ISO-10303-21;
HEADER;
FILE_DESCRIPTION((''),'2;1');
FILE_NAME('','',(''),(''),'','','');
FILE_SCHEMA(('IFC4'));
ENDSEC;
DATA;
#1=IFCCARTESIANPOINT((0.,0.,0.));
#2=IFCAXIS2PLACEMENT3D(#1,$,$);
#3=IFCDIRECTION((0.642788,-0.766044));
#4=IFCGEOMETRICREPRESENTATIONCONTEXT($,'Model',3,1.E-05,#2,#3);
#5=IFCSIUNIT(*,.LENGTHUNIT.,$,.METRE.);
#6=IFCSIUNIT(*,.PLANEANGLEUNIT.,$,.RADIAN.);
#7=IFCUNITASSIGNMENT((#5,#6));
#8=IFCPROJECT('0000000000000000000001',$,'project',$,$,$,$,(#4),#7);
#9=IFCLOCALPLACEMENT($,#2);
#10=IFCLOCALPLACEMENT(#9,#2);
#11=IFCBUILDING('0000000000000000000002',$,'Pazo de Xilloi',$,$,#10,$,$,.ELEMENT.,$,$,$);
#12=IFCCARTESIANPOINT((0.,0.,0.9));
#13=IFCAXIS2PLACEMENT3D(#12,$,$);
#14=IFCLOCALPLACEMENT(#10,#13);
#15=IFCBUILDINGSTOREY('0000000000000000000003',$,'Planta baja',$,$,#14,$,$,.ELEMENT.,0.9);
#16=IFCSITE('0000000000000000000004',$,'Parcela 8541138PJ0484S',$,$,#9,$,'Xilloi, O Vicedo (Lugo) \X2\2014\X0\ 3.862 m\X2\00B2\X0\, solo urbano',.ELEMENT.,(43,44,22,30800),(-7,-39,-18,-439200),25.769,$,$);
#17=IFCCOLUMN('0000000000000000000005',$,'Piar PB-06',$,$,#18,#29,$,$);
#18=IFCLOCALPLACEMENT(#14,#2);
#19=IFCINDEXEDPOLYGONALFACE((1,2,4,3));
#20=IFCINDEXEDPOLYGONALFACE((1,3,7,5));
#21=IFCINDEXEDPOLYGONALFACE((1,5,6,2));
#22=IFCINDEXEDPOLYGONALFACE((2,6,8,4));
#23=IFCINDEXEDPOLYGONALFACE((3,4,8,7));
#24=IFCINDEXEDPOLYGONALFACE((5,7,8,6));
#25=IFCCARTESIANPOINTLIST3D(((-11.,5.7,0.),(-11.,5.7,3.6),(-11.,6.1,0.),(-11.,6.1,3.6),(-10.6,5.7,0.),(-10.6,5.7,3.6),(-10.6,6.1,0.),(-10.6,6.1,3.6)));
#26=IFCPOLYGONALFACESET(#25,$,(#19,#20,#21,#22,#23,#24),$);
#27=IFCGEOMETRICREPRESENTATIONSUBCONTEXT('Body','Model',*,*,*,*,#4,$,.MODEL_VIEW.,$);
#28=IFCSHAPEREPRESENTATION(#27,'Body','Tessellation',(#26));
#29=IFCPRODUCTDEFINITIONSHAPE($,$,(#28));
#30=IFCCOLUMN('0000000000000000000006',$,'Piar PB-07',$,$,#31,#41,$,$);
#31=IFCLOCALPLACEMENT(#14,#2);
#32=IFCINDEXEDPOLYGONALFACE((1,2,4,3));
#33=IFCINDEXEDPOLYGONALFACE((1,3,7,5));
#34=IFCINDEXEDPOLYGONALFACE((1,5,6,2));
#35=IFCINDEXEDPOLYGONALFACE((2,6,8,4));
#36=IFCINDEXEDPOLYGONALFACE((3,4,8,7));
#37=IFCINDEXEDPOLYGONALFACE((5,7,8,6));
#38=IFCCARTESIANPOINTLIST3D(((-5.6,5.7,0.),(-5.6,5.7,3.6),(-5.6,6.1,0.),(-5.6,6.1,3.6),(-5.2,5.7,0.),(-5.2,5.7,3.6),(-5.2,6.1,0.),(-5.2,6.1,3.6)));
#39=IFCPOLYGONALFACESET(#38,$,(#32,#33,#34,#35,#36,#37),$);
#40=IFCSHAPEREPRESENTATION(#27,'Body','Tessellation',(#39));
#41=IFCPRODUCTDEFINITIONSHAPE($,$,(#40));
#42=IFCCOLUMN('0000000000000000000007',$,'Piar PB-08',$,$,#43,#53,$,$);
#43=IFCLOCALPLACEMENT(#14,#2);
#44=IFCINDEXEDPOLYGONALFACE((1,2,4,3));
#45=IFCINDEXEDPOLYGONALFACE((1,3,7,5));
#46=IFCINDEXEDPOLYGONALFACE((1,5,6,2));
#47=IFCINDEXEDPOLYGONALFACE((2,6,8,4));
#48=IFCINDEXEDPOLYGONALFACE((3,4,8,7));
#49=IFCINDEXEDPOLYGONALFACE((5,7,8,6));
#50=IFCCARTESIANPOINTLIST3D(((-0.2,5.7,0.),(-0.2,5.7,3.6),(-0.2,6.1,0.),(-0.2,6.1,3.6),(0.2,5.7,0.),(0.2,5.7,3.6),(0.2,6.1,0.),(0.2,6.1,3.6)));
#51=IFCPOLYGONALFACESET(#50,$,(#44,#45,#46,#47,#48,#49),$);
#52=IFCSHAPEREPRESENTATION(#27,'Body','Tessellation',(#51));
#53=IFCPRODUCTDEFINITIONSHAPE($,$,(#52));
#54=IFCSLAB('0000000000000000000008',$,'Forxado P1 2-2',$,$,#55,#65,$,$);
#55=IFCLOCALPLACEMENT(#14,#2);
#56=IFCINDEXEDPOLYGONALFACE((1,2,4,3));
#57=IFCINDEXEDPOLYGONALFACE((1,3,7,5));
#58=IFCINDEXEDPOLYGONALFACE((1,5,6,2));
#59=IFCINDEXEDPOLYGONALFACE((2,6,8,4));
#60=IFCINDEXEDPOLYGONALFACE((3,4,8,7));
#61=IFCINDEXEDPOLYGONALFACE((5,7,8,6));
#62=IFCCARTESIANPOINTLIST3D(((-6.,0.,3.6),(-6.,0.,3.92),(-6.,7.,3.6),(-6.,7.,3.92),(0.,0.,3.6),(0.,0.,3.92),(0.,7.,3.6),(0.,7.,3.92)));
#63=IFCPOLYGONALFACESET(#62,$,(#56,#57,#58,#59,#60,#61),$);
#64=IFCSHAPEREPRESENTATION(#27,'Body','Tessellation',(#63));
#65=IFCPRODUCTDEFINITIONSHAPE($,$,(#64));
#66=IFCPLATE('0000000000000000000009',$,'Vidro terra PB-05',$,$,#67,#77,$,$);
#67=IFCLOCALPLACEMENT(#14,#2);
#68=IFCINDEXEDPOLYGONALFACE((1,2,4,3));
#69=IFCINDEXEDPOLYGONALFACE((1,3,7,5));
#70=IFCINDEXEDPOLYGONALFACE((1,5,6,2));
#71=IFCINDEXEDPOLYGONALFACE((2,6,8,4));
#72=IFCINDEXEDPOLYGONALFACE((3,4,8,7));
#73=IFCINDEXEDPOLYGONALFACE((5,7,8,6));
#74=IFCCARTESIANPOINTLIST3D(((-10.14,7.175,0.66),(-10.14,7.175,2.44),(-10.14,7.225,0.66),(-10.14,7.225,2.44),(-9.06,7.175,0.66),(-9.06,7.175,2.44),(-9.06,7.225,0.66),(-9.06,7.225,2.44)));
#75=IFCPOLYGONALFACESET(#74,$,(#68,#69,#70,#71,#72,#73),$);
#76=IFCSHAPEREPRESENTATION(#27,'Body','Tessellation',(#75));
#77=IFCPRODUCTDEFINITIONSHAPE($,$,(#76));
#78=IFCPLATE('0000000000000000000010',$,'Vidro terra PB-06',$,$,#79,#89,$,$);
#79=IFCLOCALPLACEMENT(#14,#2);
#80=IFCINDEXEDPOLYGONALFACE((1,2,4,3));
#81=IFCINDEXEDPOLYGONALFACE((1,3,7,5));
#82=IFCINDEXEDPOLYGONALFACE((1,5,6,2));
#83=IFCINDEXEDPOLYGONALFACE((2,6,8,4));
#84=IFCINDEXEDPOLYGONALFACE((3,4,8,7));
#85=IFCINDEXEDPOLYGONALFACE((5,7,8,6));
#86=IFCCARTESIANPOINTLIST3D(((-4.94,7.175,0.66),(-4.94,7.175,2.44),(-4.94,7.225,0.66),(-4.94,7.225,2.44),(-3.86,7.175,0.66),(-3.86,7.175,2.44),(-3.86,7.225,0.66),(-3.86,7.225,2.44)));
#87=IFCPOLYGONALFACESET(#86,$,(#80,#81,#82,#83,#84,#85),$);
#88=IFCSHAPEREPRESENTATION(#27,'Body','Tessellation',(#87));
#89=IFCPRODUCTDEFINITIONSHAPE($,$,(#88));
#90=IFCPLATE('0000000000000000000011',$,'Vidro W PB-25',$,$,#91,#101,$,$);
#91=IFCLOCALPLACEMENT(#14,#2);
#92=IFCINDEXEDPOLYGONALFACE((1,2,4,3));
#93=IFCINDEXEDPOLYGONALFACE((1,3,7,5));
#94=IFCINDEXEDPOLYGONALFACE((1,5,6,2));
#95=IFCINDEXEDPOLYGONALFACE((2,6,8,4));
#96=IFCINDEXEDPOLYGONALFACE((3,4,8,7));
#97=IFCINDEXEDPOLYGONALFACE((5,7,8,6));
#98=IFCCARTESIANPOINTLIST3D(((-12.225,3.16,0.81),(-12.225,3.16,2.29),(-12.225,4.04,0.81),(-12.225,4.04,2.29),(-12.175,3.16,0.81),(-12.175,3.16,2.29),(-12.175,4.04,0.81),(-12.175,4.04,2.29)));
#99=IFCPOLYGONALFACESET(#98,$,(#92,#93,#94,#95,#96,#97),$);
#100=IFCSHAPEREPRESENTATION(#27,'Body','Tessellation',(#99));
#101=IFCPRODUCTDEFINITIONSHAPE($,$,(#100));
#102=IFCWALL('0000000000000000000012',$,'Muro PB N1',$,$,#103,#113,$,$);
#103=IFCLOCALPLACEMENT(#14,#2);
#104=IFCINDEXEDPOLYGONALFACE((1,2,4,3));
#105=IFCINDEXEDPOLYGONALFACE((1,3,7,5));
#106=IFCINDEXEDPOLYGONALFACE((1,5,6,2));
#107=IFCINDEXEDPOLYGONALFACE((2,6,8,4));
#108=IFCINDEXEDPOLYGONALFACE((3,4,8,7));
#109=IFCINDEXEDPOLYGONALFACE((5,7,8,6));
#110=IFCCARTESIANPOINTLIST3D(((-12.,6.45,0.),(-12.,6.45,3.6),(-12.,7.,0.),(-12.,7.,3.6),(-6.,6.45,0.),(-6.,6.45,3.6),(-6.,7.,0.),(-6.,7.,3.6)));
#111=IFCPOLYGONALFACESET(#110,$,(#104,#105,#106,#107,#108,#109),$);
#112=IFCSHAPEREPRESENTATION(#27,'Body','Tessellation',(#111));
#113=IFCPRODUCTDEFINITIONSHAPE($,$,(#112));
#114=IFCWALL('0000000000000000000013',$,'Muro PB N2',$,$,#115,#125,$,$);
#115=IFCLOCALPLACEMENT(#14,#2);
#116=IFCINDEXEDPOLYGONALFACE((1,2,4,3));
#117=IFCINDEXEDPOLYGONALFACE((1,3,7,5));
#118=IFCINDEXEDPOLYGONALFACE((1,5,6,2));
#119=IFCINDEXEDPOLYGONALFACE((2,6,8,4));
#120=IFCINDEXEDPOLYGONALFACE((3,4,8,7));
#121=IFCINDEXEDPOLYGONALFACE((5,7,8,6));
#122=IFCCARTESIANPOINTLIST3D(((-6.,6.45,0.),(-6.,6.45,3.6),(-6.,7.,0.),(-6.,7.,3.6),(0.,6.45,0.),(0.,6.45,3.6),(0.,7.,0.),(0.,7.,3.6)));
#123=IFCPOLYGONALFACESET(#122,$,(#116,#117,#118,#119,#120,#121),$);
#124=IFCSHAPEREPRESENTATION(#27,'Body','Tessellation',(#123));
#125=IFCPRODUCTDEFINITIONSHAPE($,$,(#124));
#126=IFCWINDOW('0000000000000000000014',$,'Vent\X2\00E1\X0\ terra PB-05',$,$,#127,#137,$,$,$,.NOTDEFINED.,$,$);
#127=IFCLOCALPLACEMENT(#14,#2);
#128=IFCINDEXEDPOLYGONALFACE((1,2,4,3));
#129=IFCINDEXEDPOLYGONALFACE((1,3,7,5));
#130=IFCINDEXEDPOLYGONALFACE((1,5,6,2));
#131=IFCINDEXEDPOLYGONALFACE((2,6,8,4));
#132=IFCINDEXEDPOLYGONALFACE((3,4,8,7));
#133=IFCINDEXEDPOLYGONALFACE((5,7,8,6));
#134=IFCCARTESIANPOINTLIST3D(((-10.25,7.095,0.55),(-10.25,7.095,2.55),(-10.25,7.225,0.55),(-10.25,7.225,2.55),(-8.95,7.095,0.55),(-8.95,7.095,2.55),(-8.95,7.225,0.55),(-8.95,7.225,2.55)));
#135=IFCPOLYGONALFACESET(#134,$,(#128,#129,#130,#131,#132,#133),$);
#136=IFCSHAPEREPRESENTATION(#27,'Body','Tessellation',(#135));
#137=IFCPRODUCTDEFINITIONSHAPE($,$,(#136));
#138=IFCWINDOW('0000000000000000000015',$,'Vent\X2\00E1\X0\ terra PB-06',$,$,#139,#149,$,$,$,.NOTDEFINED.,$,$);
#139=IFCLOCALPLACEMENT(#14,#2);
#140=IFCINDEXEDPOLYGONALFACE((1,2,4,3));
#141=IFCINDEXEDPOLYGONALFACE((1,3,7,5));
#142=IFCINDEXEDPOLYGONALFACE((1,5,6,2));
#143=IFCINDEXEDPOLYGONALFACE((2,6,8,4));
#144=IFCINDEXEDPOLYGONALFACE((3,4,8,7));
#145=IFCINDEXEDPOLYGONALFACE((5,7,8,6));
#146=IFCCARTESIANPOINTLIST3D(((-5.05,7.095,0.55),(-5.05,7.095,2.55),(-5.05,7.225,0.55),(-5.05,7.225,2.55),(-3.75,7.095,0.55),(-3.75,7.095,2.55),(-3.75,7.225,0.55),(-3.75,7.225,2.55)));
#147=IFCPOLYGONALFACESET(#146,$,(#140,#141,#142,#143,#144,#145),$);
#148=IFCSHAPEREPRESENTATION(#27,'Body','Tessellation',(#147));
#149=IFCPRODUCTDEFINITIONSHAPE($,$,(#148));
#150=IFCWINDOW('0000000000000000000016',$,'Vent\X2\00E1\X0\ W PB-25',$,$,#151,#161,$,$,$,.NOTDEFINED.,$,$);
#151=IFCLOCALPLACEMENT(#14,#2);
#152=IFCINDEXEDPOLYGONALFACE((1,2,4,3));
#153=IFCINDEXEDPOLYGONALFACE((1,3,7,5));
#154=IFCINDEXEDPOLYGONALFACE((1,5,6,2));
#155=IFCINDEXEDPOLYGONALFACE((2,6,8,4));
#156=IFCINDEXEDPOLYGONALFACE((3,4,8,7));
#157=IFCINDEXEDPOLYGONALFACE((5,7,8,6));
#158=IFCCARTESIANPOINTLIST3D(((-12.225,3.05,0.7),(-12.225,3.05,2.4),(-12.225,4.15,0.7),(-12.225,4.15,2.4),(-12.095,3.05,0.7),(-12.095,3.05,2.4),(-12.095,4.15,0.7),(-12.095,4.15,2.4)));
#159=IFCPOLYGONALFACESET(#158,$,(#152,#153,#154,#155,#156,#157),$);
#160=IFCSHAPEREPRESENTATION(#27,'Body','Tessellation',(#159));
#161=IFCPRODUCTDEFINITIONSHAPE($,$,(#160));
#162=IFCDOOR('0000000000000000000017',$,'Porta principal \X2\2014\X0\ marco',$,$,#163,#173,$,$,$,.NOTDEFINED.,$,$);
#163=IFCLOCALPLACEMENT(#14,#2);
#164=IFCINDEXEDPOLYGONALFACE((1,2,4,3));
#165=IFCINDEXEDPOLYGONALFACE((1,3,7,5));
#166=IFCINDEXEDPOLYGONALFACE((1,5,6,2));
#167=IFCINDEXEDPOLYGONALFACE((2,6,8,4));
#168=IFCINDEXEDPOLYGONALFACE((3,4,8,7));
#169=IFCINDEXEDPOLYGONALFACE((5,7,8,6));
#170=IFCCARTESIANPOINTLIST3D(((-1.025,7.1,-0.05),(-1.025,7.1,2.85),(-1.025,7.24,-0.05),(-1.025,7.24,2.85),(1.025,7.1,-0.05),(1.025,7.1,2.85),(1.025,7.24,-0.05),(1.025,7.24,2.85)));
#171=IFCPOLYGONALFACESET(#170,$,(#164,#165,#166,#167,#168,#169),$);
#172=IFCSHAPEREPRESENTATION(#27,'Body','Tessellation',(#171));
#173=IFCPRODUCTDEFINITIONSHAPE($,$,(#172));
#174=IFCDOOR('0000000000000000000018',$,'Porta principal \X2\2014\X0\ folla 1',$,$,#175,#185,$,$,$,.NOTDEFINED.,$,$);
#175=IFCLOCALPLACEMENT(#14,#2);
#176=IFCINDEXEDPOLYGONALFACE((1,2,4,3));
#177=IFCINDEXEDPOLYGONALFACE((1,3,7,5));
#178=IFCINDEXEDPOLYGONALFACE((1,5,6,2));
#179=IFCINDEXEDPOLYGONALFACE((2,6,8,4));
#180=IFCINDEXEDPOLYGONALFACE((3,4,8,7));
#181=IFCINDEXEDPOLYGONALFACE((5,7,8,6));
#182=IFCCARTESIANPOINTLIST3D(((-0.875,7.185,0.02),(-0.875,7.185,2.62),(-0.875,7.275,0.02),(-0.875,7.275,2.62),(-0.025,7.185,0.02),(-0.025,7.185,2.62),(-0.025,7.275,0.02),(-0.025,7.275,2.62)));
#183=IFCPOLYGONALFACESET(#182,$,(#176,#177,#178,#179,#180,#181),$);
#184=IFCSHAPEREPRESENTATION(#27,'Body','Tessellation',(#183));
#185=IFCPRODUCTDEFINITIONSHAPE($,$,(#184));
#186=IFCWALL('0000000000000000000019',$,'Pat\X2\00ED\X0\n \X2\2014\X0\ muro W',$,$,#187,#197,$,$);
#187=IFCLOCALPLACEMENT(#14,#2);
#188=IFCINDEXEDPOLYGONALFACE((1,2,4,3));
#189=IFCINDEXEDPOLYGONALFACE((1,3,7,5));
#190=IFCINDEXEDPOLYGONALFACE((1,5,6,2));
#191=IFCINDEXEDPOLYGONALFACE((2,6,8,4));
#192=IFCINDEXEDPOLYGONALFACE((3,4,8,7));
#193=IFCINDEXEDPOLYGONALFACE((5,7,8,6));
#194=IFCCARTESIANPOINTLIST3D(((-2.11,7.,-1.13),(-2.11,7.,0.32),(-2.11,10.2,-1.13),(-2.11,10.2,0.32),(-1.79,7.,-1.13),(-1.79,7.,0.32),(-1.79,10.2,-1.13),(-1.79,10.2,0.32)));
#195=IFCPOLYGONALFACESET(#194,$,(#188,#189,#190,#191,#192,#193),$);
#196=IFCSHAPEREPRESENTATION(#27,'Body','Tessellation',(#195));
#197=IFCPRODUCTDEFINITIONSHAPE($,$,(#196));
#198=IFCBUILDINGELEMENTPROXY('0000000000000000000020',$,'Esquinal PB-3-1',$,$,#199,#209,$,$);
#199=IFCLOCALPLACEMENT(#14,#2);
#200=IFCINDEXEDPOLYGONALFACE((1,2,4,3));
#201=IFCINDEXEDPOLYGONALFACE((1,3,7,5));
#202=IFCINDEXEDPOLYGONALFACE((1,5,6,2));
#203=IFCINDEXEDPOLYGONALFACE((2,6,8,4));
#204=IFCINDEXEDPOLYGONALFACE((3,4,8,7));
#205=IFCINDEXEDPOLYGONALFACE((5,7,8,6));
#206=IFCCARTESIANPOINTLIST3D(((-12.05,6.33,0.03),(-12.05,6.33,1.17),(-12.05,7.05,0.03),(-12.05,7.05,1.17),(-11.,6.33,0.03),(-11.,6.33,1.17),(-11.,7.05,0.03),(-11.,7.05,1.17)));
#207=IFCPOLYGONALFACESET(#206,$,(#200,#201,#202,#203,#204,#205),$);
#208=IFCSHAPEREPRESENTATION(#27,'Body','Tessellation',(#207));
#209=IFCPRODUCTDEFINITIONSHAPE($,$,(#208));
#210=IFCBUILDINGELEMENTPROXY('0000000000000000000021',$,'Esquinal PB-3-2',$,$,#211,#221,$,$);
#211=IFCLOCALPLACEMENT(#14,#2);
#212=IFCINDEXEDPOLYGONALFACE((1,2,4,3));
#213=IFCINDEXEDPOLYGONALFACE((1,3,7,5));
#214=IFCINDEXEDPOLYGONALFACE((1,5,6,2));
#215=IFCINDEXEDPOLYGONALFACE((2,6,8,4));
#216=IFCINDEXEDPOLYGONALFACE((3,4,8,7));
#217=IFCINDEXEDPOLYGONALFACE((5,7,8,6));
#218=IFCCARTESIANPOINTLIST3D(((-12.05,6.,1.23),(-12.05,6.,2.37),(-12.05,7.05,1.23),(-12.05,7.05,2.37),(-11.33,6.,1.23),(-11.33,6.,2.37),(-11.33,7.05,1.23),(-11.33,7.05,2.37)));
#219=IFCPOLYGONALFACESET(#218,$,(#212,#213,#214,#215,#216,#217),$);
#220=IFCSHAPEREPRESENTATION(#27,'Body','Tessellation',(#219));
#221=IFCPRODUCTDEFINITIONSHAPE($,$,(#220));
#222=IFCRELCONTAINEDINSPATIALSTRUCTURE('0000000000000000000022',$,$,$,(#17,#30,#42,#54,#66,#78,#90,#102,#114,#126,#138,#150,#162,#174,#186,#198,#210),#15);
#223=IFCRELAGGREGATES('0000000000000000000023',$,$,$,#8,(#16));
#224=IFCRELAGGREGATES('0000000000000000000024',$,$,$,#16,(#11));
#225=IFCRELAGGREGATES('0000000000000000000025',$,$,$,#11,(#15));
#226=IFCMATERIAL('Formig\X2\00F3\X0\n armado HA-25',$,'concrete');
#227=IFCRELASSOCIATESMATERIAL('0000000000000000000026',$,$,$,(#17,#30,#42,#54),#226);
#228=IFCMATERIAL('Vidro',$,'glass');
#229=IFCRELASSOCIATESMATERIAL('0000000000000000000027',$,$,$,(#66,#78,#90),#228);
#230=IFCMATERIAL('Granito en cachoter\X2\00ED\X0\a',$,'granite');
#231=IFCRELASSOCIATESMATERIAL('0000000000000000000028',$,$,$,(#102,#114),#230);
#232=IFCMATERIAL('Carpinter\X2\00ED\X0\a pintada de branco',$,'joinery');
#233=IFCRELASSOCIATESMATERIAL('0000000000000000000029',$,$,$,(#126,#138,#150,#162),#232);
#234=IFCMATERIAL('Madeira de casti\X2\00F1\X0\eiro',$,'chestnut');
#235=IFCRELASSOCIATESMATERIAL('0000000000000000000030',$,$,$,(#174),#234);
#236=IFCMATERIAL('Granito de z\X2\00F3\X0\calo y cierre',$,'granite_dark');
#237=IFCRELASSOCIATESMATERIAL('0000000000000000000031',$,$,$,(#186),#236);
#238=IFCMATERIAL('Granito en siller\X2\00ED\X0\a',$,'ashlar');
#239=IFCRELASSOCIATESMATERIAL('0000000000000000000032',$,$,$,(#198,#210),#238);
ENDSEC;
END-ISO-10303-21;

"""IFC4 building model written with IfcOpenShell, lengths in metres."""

from ifc_helpers import new_model, si_unit, direction, frame, origin, origin_2d, place, context, subcontext, project, spatial, rectangle, extrude, material, element, save


model = new_model("IFC4")

# Units and contexts
model_context = context("Model", 3, precision=1e-05, world=origin(), true_north=direction((0.642788, -0.766044)))
body_context = subcontext(model_context, "Body", "Model", "MODEL_VIEW")
ifc_project = project(units=[si_unit("LENGTHUNIT", "METRE"), si_unit("PLANEANGLEUNIT", "RADIAN")], contexts=[model_context])

# Site, building, storey
site_placement = place(None, origin())
site = spatial("IfcSite", under=ifc_project, at=site_placement, Name="Parcela 8541138PJ0484S", LongName="Xilloi, O Vicedo (Lugo) — 3.862 m², solo urbano", CompositionType="ELEMENT", RefLatitude=(43, 44, 22, 30800), RefLongitude=(-7, -39, -18, -439200), RefElevation=25.769)
building_placement = place(site_placement, origin())
building = spatial("IfcBuilding", under=site, at=building_placement, Name="Pazo de Xilloi", CompositionType="ELEMENT")
storey_placement = place(building_placement, frame((0.0, 0.0, 0.9)))
storey = spatial("IfcBuildingStorey", under=building, at=storey_placement, Name="Planta baja", CompositionType="ELEMENT", Elevation=0.9)

# Columns
ifc_material_1 = material(Name="Formigón armado HA-25", Category="concrete")
for number, where, name in (
    (1, (-10.8, 5.9, 1.8), "Piar PB-06"),
    (2, (-5.4, 5.9, 1.8), "Piar PB-07"),
    (3, (0.0, 5.9, 1.8), "Piar PB-08"),
):
    element("IfcColumn", number, at=place(storey_placement, frame(where)), inside=storey, material=ifc_material_1, Name=name, context=body_context, shape_type="SweptSolid", body=[
        extrude(rectangle(XDim=0.4, YDim=0.4, at=origin_2d()), frame((0.0, 0.0, -1.8)), (0.0, 0.0, 1.0), 3.6),
    ])

# Slab
slab_placement = place(storey_placement, frame((-3.0, 3.5, 3.76)))
element("IfcSlab", 4, at=slab_placement, inside=storey, material=ifc_material_1, Name="Forxado P1 2-2", context=body_context, shape_type="SweptSolid", body=[
    extrude(rectangle(XDim=6.0, YDim=7.0, at=origin_2d()), frame((0.0, 0.0, -0.16)), (0.0, 0.0, 1.0), 0.32),
])

# Plates
ifc_material_2 = material(Name="Vidro", Category="glass")
for number, where, name in (
    (5, (-9.6, 7.2, 1.55), "Vidro terra PB-05"),
    (6, (-4.4, 7.2, 1.55), "Vidro terra PB-06"),
):
    element("IfcPlate", number, at=place(storey_placement, frame(where)), inside=storey, material=ifc_material_2, Name=name, context=body_context, shape_type="SweptSolid", body=[
        extrude(rectangle(XDim=1.08, YDim=0.05, at=origin_2d()), frame((0.0, 0.0, -0.89)), (0.0, 0.0, 1.0), 1.78),
    ])
plate_placement = place(storey_placement, frame((-12.2, 3.6, 1.55)))
element("IfcPlate", 7, at=plate_placement, inside=storey, material=ifc_material_2, Name="Vidro W PB-25", context=body_context, shape_type="SweptSolid", body=[
    extrude(rectangle(XDim=0.05, YDim=0.88, at=origin_2d()), frame((0.0, 0.0, -0.74)), (0.0, 0.0, 1.0), 1.48),
])

# Walls
ifc_material_3 = material(Name="Granito en cachotería", Category="granite")
for number, where, name in (
    (8, (-9.0, 6.725, 1.8), "Muro PB N1"),
    (9, (-3.0, 6.725, 1.8), "Muro PB N2"),
):
    element("IfcWall", number, at=place(storey_placement, frame(where)), inside=storey, material=ifc_material_3, Name=name, context=body_context, shape_type="SweptSolid", body=[
        extrude(rectangle(XDim=6.0, YDim=0.55, at=origin_2d()), frame((0.0, 0.0, -1.8)), (0.0, 0.0, 1.0), 3.6),
    ])

# Windows
ifc_material_4 = material(Name="Carpintería pintada de branco", Category="joinery")
for number, where, name in (
    (10, (-9.6, 7.16, 1.55), "Ventá terra PB-05"),
    (11, (-4.4, 7.16, 1.55), "Ventá terra PB-06"),
):
    element("IfcWindow", number, at=place(storey_placement, frame(where)), inside=storey, material=ifc_material_4, Name=name, PredefinedType="NOTDEFINED", context=body_context, shape_type="SweptSolid", body=[
        extrude(rectangle(XDim=1.3, YDim=0.13, at=origin_2d()), frame((0.0, 0.0, -1.0)), (0.0, 0.0, 1.0), 2.0),
    ])
window_placement = place(storey_placement, frame((-12.16, 3.6, 1.55)))
element("IfcWindow", 12, at=window_placement, inside=storey, material=ifc_material_4, Name="Ventá W PB-25", PredefinedType="NOTDEFINED", context=body_context, shape_type="SweptSolid", body=[
    extrude(rectangle(XDim=0.13, YDim=1.1, at=origin_2d()), frame((0.0, 0.0, -0.85)), (0.0, 0.0, 1.0), 1.7),
])

# Doors
door_1_placement = place(storey_placement, frame((0.0, 7.17, 1.4)))
element("IfcDoor", 13, at=door_1_placement, inside=storey, material=ifc_material_4, Name="Porta principal — marco", PredefinedType="NOTDEFINED", context=body_context, shape_type="SweptSolid", body=[
    extrude(rectangle(XDim=2.05, YDim=0.14, at=origin_2d()), frame((0.0, 0.0, -1.45)), (0.0, 0.0, 1.0), 2.9),
])
ifc_material_5 = material(Name="Madeira de castiñeiro", Category="chestnut")
door_2_placement = place(storey_placement, frame((-0.45, 7.23, 1.32)))
element("IfcDoor", 14, at=door_2_placement, inside=storey, material=ifc_material_5, Name="Porta principal — folla 1", PredefinedType="NOTDEFINED", context=body_context, shape_type="SweptSolid", body=[
    extrude(rectangle(XDim=0.85, YDim=0.09, at=origin_2d()), frame((0.0, 0.0, -1.3)), (0.0, 0.0, 1.0), 2.6),
])

# Wall
ifc_material_6 = material(Name="Granito de zócalo y cierre", Category="granite_dark")
wall_placement = place(storey_placement, frame((-1.95, 8.6, -0.405)))
element("IfcWall", 15, at=wall_placement, inside=storey, material=ifc_material_6, Name="Patín — muro W", context=body_context, shape_type="SweptSolid", body=[
    extrude(rectangle(XDim=0.32, YDim=3.2, at=origin_2d()), frame((0.0, 0.0, -0.725)), (0.0, 0.0, 1.0), 1.45),
])

# Building element proxies
ifc_material_7 = material(Name="Granito en sillería", Category="ashlar")
proxy_1_placement = place(storey_placement, frame((-11.525, 6.69, 0.6)))
element("IfcBuildingElementProxy", 16, at=proxy_1_placement, inside=storey, material=ifc_material_7, Name="Esquinal PB-3-1", context=body_context, shape_type="SweptSolid", body=[
    extrude(rectangle(XDim=1.05, YDim=0.72, at=origin_2d()), frame((0.0, 0.0, -0.57)), (0.0, 0.0, 1.0), 1.14),
])
proxy_2_placement = place(storey_placement, frame((-11.69, 6.525, 1.8)))
element("IfcBuildingElementProxy", 17, at=proxy_2_placement, inside=storey, material=ifc_material_7, Name="Esquinal PB-3-2", context=body_context, shape_type="SweptSolid", body=[
    extrude(rectangle(XDim=0.72, YDim=1.05, at=origin_2d()), frame((0.0, 0.0, -0.57)), (0.0, 0.0, 1.0), 1.14),
])

save(model, "model.ifc")
